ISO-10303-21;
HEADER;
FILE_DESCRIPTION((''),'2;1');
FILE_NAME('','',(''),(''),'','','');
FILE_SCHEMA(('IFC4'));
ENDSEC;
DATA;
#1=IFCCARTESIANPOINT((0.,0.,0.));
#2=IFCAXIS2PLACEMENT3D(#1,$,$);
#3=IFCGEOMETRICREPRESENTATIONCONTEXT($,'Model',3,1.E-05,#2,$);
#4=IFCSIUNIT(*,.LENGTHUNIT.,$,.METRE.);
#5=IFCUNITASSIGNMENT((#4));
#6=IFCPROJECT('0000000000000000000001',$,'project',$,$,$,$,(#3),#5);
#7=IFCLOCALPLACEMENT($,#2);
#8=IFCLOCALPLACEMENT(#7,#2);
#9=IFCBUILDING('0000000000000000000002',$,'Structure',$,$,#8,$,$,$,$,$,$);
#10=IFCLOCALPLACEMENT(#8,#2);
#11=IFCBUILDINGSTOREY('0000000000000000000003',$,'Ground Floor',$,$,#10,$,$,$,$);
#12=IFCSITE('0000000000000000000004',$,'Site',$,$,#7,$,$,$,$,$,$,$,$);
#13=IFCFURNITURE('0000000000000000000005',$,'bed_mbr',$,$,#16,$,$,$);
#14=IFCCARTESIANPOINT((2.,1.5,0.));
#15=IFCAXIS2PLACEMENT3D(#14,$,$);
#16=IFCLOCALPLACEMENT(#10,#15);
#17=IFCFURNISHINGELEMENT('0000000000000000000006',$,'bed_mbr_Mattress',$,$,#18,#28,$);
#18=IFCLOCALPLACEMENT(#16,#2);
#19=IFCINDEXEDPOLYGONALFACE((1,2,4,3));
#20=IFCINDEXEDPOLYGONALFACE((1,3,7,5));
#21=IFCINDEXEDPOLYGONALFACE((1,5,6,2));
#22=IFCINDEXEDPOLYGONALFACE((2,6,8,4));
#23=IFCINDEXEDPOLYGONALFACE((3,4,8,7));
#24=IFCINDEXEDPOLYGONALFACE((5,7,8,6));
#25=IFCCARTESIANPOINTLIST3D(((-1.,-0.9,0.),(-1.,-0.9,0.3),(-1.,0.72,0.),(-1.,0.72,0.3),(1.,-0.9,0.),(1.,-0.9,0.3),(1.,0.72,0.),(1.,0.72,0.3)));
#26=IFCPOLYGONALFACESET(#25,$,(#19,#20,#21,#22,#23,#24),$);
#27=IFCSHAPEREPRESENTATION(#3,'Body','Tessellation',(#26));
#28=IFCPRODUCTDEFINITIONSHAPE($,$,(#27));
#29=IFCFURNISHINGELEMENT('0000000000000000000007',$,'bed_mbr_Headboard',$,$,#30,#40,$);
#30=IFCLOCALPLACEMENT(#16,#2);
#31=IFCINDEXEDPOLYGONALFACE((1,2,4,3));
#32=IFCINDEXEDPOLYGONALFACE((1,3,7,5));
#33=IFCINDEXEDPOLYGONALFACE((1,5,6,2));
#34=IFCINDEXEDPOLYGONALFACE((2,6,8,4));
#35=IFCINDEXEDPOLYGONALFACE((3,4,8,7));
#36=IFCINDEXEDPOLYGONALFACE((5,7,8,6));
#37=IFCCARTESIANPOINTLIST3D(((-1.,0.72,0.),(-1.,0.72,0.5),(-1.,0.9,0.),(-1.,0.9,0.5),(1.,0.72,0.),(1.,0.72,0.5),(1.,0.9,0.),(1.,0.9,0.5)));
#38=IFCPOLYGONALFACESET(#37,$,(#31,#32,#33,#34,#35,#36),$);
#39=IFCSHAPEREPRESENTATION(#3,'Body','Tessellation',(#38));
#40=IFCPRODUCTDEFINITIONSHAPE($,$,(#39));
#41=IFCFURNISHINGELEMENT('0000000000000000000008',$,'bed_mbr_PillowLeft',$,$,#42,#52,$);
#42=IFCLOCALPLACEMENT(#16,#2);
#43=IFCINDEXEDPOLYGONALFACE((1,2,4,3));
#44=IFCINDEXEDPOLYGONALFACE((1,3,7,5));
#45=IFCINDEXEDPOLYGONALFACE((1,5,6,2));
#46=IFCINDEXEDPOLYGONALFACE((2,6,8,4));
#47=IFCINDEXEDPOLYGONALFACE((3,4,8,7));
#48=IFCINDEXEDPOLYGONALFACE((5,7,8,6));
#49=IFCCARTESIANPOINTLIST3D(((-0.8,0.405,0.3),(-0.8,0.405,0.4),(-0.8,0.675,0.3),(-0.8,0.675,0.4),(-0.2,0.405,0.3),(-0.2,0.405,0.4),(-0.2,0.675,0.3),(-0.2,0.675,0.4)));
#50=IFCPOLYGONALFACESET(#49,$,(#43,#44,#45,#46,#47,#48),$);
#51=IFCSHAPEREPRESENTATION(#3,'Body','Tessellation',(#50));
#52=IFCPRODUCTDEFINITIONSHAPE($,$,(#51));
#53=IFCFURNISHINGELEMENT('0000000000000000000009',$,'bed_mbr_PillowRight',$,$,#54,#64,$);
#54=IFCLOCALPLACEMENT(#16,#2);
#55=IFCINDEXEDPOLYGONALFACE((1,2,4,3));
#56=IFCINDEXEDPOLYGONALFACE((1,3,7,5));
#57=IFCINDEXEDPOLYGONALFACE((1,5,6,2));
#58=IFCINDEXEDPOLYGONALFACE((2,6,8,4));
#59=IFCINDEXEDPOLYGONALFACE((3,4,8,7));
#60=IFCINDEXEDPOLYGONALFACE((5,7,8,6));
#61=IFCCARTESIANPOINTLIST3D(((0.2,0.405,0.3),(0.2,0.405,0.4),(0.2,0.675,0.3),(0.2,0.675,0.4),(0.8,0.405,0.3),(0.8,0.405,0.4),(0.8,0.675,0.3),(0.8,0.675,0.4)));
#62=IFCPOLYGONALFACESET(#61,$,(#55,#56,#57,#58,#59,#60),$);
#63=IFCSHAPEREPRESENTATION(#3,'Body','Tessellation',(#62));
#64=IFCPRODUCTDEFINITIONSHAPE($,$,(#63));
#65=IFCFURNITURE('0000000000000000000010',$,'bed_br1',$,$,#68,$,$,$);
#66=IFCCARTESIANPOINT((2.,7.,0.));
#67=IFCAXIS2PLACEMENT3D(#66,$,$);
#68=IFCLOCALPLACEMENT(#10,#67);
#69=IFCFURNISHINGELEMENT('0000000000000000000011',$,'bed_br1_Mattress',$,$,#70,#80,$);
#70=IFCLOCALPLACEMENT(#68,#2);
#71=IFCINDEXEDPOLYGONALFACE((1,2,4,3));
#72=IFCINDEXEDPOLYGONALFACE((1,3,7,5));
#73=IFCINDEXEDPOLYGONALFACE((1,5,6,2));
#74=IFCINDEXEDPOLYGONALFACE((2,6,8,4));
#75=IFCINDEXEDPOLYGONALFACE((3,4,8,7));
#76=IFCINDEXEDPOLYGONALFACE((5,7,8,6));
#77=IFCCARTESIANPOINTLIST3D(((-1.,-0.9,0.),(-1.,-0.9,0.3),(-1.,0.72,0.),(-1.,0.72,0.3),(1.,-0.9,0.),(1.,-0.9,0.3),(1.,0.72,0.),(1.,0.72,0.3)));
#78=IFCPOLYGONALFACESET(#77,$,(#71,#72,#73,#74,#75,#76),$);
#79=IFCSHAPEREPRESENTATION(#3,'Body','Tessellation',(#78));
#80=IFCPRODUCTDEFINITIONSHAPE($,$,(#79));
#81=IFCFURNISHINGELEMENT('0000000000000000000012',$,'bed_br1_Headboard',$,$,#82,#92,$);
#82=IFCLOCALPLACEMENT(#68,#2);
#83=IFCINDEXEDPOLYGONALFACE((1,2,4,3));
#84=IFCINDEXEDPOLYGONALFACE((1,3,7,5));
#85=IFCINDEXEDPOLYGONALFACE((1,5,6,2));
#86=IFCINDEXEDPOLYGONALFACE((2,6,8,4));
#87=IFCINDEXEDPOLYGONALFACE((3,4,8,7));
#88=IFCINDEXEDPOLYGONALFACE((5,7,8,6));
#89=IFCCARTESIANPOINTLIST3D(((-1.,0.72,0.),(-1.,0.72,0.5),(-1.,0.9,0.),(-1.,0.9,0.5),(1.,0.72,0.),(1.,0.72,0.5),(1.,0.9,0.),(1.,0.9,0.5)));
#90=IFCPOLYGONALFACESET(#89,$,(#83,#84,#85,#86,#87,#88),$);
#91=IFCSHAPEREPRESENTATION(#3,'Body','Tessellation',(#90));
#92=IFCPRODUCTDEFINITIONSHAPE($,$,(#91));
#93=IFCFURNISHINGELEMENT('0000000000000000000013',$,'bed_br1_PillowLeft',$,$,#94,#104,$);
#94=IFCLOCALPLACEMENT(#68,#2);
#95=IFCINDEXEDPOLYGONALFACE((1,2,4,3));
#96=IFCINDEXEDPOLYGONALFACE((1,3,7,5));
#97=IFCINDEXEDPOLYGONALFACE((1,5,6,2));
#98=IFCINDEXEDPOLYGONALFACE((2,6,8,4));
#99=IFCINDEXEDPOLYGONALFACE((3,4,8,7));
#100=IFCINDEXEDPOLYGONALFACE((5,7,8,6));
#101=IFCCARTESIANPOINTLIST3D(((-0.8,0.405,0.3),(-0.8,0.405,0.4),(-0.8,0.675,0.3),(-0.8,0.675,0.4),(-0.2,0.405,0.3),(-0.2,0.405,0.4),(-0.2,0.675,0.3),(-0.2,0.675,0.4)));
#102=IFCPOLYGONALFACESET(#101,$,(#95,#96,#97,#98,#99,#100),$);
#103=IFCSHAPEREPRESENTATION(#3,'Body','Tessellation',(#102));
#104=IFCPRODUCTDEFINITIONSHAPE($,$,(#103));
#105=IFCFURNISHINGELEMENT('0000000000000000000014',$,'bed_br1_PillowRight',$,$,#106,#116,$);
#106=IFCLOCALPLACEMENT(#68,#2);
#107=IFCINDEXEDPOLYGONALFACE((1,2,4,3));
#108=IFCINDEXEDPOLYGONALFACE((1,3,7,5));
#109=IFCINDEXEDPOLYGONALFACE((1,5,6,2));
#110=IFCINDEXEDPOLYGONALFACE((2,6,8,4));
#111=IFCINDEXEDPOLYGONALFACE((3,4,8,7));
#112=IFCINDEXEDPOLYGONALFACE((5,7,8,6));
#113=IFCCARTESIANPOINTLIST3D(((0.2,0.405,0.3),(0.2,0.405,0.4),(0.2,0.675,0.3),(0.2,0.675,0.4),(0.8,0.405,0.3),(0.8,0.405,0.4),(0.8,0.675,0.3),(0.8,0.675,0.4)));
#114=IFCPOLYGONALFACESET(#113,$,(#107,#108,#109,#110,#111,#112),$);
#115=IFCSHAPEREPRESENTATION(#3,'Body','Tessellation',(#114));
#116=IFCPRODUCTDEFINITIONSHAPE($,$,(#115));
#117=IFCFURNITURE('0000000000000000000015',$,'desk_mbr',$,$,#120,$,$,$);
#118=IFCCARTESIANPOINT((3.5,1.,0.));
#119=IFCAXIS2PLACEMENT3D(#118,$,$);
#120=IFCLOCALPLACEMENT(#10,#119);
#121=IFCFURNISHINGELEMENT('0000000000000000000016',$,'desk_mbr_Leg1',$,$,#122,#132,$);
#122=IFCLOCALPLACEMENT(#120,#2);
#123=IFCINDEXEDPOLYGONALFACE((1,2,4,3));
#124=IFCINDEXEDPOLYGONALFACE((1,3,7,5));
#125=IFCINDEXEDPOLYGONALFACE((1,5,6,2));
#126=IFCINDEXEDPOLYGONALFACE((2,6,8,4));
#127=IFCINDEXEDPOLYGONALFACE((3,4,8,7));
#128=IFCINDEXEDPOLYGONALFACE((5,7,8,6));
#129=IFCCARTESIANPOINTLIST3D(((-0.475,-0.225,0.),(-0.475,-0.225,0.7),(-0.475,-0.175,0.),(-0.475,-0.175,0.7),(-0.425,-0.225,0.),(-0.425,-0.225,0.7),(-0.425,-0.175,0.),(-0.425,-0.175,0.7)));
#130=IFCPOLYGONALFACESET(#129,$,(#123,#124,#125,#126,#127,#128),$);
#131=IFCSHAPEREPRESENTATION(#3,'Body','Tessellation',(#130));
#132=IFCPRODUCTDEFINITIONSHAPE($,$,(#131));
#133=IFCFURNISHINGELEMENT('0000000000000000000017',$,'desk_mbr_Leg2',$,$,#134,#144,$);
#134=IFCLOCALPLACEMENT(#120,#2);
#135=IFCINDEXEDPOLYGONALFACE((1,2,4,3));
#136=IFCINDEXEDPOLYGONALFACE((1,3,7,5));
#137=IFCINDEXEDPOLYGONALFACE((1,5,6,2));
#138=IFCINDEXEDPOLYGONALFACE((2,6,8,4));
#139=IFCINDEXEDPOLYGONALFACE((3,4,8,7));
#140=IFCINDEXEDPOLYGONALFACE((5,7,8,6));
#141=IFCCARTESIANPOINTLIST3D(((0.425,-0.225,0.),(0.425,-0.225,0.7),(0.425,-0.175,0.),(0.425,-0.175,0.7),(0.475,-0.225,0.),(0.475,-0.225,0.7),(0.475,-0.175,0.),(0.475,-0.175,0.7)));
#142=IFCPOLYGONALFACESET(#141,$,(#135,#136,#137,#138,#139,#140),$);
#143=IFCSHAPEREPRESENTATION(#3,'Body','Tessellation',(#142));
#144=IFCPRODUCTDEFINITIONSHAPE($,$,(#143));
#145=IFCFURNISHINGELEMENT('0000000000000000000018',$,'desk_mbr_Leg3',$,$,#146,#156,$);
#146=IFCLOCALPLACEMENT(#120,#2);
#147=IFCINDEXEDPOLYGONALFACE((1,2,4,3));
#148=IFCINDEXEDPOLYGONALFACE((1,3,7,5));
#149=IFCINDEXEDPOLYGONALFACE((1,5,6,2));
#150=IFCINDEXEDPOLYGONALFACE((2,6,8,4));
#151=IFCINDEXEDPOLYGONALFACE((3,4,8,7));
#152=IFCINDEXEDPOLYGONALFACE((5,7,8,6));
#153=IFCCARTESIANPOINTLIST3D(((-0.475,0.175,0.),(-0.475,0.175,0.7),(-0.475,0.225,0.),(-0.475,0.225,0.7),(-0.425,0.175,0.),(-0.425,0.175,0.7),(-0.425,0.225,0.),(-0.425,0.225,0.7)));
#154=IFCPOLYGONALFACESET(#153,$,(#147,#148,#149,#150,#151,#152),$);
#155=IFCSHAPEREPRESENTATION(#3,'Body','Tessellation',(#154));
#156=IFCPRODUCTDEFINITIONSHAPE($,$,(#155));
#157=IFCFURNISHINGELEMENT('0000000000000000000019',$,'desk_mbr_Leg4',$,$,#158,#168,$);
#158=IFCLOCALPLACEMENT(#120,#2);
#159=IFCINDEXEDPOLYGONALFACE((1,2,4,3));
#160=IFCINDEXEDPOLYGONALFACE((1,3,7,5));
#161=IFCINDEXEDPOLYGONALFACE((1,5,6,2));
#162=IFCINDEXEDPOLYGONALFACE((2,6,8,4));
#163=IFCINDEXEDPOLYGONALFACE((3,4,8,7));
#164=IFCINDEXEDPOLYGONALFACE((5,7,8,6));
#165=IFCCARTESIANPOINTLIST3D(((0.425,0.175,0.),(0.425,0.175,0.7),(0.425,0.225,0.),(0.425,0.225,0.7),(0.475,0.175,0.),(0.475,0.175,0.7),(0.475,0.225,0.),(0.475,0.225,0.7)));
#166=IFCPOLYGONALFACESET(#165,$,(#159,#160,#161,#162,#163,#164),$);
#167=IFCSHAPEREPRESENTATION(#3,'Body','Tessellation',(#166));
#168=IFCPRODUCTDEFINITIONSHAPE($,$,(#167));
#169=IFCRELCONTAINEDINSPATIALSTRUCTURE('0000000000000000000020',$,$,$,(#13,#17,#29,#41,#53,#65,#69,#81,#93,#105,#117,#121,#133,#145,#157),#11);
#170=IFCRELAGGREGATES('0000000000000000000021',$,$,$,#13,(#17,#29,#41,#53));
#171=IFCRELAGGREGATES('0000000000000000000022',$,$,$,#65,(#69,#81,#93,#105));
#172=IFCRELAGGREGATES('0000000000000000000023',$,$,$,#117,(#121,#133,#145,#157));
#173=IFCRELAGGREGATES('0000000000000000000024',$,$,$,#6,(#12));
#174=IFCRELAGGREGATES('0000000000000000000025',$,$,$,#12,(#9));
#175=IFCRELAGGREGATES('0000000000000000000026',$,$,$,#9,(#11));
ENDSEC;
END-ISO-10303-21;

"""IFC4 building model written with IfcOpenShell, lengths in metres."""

from ifc_helpers import new_model, si_unit, frame, origin, origin_2d, place, context, project, spatial, rectangle, extrude, element, aggregate, save


model = new_model("IFC4")

# Units and contexts
model_context = context("Model", 3, precision=1e-05, world=origin())
ifc_project = project(units=[si_unit("LENGTHUNIT", "METRE")], contexts=[model_context])

# Site, building, storey
site_placement = place(None, origin())
site = spatial("IfcSite", under=ifc_project, at=site_placement, Name="Site")
building_placement = place(site_placement, origin())
building = spatial("IfcBuilding", under=site, at=building_placement, Name="Structure")
storey_placement = place(building_placement, origin())
storey = spatial("IfcBuildingStorey", under=building, at=storey_placement, Name="Ground Floor")

# Furniture, furnishing elements
furniture_1_placement = place(storey_placement, frame((2.0, 1.5, 0.0)))
furniture_1 = element("IfcFurniture", 1, at=furniture_1_placement, inside=storey, Name="bed_mbr")
furnishing_1_placement = place(furniture_1_placement, origin())
furnishing_1 = element("IfcFurnishingElement", 2, at=furnishing_1_placement, inside=storey, Name="bed_mbr_Mattress", context=model_context, shape_type="SweptSolid", body=[
    extrude(rectangle(XDim=2.0, YDim=1.62, at=origin_2d()), frame((0.0, -0.09, 0.0)), (0.0, 0.0, 1.0), 0.3),
])
furnishing_2_placement = place(furniture_1_placement, origin())
furnishing_2 = element("IfcFurnishingElement", 3, at=furnishing_2_placement, inside=storey, Name="bed_mbr_Headboard", context=model_context, shape_type="SweptSolid", body=[
    extrude(rectangle(XDim=2.0, YDim=0.18, at=origin_2d()), frame((0.0, 0.81, 0.0)), (0.0, 0.0, 1.0), 0.5),
])
furnishing_3_placement = place(furniture_1_placement, origin())
furnishing_3 = element("IfcFurnishingElement", 4, at=furnishing_3_placement, inside=storey, Name="bed_mbr_PillowLeft", context=model_context, shape_type="SweptSolid", body=[
    extrude(rectangle(XDim=0.6, YDim=0.27, at=origin_2d()), frame((-0.5, 0.54, 0.3)), (0.0, 0.0, 1.0), 0.1),
])
furnishing_4_placement = place(furniture_1_placement, origin())
furnishing_4 = element("IfcFurnishingElement", 5, at=furnishing_4_placement, inside=storey, Name="bed_mbr_PillowRight", context=model_context, shape_type="SweptSolid", body=[
    extrude(rectangle(XDim=0.6, YDim=0.27, at=origin_2d()), frame((0.5, 0.54, 0.3)), (0.0, 0.0, 1.0), 0.1),
])
aggregate(furniture_1, [furnishing_1, furnishing_2, furnishing_3, furnishing_4])
furniture_2_placement = place(storey_placement, frame((2.0, 7.0, 0.0)))
furniture_2 = element("IfcFurniture", 6, at=furniture_2_placement, inside=storey, Name="bed_br1")
furnishing_5_placement = place(furniture_2_placement, origin())
furnishing_5 = element("IfcFurnishingElement", 7, at=furnishing_5_placement, inside=storey, Name="bed_br1_Mattress", context=model_context, shape_type="SweptSolid", body=[
    extrude(rectangle(XDim=2.0, YDim=1.62, at=origin_2d()), frame((0.0, -0.09, 0.0)), (0.0, 0.0, 1.0), 0.3),
])
furnishing_6_placement = place(furniture_2_placement, origin())
furnishing_6 = element("IfcFurnishingElement", 8, at=furnishing_6_placement, inside=storey, Name="bed_br1_Headboard", context=model_context, shape_type="SweptSolid", body=[
    extrude(rectangle(XDim=2.0, YDim=0.18, at=origin_2d()), frame((0.0, 0.81, 0.0)), (0.0, 0.0, 1.0), 0.5),
])
furnishing_7_placement = place(furniture_2_placement, origin())
furnishing_7 = element("IfcFurnishingElement", 9, at=furnishing_7_placement, inside=storey, Name="bed_br1_PillowLeft", context=model_context, shape_type="SweptSolid", body=[
    extrude(rectangle(XDim=0.6, YDim=0.27, at=origin_2d()), frame((-0.5, 0.54, 0.3)), (0.0, 0.0, 1.0), 0.1),
])
furnishing_8_placement = place(furniture_2_placement, origin())
furnishing_8 = element("IfcFurnishingElement", 10, at=furnishing_8_placement, inside=storey, Name="bed_br1_PillowRight", context=model_context, shape_type="SweptSolid", body=[
    extrude(rectangle(XDim=0.6, YDim=0.27, at=origin_2d()), frame((0.5, 0.54, 0.3)), (0.0, 0.0, 1.0), 0.1),
])
aggregate(furniture_2, [furnishing_5, furnishing_6, furnishing_7, furnishing_8])

# Furniture, furnishing elements
furniture_3_placement = place(storey_placement, frame((3.5, 1.0, 0.0)))
furniture_3 = element("IfcFurniture", 11, at=furniture_3_placement, inside=storey, Name="desk_mbr")
furnishing_9_placement = place(furniture_3_placement, origin())
furnishing_9 = element("IfcFurnishingElement", 12, at=furnishing_9_placement, inside=storey, Name="desk_mbr_Leg1", context=model_context, shape_type="SweptSolid", body=[
    extrude(rectangle(XDim=0.05, YDim=0.05, at=origin_2d()), frame((-0.45, -0.2, 0.0)), (0.0, 0.0, 1.0), 0.7),
])
furnishing_10_placement = place(furniture_3_placement, origin())
furnishing_10 = element("IfcFurnishingElement", 13, at=furnishing_10_placement, inside=storey, Name="desk_mbr_Leg2", context=model_context, shape_type="SweptSolid", body=[
    extrude(rectangle(XDim=0.05, YDim=0.05, at=origin_2d()), frame((0.45, -0.2, 0.0)), (0.0, 0.0, 1.0), 0.7),
])
furnishing_11_placement = place(furniture_3_placement, origin())
furnishing_11 = element("IfcFurnishingElement", 14, at=furnishing_11_placement, inside=storey, Name="desk_mbr_Leg3", context=model_context, shape_type="SweptSolid", body=[
    extrude(rectangle(XDim=0.05, YDim=0.05, at=origin_2d()), frame((-0.45, 0.2, 0.0)), (0.0, 0.0, 1.0), 0.7),
])
furnishing_12_placement = place(furniture_3_placement, origin())
furnishing_12 = element("IfcFurnishingElement", 15, at=furnishing_12_placement, inside=storey, Name="desk_mbr_Leg4", context=model_context, shape_type="SweptSolid", body=[
    extrude(rectangle(XDim=0.05, YDim=0.05, at=origin_2d()), frame((0.45, 0.2, 0.0)), (0.0, 0.0, 1.0), 0.7),
])
aggregate(furniture_3, [furnishing_9, furnishing_10, furnishing_11, furnishing_12])

save(model, "model.ifc")
